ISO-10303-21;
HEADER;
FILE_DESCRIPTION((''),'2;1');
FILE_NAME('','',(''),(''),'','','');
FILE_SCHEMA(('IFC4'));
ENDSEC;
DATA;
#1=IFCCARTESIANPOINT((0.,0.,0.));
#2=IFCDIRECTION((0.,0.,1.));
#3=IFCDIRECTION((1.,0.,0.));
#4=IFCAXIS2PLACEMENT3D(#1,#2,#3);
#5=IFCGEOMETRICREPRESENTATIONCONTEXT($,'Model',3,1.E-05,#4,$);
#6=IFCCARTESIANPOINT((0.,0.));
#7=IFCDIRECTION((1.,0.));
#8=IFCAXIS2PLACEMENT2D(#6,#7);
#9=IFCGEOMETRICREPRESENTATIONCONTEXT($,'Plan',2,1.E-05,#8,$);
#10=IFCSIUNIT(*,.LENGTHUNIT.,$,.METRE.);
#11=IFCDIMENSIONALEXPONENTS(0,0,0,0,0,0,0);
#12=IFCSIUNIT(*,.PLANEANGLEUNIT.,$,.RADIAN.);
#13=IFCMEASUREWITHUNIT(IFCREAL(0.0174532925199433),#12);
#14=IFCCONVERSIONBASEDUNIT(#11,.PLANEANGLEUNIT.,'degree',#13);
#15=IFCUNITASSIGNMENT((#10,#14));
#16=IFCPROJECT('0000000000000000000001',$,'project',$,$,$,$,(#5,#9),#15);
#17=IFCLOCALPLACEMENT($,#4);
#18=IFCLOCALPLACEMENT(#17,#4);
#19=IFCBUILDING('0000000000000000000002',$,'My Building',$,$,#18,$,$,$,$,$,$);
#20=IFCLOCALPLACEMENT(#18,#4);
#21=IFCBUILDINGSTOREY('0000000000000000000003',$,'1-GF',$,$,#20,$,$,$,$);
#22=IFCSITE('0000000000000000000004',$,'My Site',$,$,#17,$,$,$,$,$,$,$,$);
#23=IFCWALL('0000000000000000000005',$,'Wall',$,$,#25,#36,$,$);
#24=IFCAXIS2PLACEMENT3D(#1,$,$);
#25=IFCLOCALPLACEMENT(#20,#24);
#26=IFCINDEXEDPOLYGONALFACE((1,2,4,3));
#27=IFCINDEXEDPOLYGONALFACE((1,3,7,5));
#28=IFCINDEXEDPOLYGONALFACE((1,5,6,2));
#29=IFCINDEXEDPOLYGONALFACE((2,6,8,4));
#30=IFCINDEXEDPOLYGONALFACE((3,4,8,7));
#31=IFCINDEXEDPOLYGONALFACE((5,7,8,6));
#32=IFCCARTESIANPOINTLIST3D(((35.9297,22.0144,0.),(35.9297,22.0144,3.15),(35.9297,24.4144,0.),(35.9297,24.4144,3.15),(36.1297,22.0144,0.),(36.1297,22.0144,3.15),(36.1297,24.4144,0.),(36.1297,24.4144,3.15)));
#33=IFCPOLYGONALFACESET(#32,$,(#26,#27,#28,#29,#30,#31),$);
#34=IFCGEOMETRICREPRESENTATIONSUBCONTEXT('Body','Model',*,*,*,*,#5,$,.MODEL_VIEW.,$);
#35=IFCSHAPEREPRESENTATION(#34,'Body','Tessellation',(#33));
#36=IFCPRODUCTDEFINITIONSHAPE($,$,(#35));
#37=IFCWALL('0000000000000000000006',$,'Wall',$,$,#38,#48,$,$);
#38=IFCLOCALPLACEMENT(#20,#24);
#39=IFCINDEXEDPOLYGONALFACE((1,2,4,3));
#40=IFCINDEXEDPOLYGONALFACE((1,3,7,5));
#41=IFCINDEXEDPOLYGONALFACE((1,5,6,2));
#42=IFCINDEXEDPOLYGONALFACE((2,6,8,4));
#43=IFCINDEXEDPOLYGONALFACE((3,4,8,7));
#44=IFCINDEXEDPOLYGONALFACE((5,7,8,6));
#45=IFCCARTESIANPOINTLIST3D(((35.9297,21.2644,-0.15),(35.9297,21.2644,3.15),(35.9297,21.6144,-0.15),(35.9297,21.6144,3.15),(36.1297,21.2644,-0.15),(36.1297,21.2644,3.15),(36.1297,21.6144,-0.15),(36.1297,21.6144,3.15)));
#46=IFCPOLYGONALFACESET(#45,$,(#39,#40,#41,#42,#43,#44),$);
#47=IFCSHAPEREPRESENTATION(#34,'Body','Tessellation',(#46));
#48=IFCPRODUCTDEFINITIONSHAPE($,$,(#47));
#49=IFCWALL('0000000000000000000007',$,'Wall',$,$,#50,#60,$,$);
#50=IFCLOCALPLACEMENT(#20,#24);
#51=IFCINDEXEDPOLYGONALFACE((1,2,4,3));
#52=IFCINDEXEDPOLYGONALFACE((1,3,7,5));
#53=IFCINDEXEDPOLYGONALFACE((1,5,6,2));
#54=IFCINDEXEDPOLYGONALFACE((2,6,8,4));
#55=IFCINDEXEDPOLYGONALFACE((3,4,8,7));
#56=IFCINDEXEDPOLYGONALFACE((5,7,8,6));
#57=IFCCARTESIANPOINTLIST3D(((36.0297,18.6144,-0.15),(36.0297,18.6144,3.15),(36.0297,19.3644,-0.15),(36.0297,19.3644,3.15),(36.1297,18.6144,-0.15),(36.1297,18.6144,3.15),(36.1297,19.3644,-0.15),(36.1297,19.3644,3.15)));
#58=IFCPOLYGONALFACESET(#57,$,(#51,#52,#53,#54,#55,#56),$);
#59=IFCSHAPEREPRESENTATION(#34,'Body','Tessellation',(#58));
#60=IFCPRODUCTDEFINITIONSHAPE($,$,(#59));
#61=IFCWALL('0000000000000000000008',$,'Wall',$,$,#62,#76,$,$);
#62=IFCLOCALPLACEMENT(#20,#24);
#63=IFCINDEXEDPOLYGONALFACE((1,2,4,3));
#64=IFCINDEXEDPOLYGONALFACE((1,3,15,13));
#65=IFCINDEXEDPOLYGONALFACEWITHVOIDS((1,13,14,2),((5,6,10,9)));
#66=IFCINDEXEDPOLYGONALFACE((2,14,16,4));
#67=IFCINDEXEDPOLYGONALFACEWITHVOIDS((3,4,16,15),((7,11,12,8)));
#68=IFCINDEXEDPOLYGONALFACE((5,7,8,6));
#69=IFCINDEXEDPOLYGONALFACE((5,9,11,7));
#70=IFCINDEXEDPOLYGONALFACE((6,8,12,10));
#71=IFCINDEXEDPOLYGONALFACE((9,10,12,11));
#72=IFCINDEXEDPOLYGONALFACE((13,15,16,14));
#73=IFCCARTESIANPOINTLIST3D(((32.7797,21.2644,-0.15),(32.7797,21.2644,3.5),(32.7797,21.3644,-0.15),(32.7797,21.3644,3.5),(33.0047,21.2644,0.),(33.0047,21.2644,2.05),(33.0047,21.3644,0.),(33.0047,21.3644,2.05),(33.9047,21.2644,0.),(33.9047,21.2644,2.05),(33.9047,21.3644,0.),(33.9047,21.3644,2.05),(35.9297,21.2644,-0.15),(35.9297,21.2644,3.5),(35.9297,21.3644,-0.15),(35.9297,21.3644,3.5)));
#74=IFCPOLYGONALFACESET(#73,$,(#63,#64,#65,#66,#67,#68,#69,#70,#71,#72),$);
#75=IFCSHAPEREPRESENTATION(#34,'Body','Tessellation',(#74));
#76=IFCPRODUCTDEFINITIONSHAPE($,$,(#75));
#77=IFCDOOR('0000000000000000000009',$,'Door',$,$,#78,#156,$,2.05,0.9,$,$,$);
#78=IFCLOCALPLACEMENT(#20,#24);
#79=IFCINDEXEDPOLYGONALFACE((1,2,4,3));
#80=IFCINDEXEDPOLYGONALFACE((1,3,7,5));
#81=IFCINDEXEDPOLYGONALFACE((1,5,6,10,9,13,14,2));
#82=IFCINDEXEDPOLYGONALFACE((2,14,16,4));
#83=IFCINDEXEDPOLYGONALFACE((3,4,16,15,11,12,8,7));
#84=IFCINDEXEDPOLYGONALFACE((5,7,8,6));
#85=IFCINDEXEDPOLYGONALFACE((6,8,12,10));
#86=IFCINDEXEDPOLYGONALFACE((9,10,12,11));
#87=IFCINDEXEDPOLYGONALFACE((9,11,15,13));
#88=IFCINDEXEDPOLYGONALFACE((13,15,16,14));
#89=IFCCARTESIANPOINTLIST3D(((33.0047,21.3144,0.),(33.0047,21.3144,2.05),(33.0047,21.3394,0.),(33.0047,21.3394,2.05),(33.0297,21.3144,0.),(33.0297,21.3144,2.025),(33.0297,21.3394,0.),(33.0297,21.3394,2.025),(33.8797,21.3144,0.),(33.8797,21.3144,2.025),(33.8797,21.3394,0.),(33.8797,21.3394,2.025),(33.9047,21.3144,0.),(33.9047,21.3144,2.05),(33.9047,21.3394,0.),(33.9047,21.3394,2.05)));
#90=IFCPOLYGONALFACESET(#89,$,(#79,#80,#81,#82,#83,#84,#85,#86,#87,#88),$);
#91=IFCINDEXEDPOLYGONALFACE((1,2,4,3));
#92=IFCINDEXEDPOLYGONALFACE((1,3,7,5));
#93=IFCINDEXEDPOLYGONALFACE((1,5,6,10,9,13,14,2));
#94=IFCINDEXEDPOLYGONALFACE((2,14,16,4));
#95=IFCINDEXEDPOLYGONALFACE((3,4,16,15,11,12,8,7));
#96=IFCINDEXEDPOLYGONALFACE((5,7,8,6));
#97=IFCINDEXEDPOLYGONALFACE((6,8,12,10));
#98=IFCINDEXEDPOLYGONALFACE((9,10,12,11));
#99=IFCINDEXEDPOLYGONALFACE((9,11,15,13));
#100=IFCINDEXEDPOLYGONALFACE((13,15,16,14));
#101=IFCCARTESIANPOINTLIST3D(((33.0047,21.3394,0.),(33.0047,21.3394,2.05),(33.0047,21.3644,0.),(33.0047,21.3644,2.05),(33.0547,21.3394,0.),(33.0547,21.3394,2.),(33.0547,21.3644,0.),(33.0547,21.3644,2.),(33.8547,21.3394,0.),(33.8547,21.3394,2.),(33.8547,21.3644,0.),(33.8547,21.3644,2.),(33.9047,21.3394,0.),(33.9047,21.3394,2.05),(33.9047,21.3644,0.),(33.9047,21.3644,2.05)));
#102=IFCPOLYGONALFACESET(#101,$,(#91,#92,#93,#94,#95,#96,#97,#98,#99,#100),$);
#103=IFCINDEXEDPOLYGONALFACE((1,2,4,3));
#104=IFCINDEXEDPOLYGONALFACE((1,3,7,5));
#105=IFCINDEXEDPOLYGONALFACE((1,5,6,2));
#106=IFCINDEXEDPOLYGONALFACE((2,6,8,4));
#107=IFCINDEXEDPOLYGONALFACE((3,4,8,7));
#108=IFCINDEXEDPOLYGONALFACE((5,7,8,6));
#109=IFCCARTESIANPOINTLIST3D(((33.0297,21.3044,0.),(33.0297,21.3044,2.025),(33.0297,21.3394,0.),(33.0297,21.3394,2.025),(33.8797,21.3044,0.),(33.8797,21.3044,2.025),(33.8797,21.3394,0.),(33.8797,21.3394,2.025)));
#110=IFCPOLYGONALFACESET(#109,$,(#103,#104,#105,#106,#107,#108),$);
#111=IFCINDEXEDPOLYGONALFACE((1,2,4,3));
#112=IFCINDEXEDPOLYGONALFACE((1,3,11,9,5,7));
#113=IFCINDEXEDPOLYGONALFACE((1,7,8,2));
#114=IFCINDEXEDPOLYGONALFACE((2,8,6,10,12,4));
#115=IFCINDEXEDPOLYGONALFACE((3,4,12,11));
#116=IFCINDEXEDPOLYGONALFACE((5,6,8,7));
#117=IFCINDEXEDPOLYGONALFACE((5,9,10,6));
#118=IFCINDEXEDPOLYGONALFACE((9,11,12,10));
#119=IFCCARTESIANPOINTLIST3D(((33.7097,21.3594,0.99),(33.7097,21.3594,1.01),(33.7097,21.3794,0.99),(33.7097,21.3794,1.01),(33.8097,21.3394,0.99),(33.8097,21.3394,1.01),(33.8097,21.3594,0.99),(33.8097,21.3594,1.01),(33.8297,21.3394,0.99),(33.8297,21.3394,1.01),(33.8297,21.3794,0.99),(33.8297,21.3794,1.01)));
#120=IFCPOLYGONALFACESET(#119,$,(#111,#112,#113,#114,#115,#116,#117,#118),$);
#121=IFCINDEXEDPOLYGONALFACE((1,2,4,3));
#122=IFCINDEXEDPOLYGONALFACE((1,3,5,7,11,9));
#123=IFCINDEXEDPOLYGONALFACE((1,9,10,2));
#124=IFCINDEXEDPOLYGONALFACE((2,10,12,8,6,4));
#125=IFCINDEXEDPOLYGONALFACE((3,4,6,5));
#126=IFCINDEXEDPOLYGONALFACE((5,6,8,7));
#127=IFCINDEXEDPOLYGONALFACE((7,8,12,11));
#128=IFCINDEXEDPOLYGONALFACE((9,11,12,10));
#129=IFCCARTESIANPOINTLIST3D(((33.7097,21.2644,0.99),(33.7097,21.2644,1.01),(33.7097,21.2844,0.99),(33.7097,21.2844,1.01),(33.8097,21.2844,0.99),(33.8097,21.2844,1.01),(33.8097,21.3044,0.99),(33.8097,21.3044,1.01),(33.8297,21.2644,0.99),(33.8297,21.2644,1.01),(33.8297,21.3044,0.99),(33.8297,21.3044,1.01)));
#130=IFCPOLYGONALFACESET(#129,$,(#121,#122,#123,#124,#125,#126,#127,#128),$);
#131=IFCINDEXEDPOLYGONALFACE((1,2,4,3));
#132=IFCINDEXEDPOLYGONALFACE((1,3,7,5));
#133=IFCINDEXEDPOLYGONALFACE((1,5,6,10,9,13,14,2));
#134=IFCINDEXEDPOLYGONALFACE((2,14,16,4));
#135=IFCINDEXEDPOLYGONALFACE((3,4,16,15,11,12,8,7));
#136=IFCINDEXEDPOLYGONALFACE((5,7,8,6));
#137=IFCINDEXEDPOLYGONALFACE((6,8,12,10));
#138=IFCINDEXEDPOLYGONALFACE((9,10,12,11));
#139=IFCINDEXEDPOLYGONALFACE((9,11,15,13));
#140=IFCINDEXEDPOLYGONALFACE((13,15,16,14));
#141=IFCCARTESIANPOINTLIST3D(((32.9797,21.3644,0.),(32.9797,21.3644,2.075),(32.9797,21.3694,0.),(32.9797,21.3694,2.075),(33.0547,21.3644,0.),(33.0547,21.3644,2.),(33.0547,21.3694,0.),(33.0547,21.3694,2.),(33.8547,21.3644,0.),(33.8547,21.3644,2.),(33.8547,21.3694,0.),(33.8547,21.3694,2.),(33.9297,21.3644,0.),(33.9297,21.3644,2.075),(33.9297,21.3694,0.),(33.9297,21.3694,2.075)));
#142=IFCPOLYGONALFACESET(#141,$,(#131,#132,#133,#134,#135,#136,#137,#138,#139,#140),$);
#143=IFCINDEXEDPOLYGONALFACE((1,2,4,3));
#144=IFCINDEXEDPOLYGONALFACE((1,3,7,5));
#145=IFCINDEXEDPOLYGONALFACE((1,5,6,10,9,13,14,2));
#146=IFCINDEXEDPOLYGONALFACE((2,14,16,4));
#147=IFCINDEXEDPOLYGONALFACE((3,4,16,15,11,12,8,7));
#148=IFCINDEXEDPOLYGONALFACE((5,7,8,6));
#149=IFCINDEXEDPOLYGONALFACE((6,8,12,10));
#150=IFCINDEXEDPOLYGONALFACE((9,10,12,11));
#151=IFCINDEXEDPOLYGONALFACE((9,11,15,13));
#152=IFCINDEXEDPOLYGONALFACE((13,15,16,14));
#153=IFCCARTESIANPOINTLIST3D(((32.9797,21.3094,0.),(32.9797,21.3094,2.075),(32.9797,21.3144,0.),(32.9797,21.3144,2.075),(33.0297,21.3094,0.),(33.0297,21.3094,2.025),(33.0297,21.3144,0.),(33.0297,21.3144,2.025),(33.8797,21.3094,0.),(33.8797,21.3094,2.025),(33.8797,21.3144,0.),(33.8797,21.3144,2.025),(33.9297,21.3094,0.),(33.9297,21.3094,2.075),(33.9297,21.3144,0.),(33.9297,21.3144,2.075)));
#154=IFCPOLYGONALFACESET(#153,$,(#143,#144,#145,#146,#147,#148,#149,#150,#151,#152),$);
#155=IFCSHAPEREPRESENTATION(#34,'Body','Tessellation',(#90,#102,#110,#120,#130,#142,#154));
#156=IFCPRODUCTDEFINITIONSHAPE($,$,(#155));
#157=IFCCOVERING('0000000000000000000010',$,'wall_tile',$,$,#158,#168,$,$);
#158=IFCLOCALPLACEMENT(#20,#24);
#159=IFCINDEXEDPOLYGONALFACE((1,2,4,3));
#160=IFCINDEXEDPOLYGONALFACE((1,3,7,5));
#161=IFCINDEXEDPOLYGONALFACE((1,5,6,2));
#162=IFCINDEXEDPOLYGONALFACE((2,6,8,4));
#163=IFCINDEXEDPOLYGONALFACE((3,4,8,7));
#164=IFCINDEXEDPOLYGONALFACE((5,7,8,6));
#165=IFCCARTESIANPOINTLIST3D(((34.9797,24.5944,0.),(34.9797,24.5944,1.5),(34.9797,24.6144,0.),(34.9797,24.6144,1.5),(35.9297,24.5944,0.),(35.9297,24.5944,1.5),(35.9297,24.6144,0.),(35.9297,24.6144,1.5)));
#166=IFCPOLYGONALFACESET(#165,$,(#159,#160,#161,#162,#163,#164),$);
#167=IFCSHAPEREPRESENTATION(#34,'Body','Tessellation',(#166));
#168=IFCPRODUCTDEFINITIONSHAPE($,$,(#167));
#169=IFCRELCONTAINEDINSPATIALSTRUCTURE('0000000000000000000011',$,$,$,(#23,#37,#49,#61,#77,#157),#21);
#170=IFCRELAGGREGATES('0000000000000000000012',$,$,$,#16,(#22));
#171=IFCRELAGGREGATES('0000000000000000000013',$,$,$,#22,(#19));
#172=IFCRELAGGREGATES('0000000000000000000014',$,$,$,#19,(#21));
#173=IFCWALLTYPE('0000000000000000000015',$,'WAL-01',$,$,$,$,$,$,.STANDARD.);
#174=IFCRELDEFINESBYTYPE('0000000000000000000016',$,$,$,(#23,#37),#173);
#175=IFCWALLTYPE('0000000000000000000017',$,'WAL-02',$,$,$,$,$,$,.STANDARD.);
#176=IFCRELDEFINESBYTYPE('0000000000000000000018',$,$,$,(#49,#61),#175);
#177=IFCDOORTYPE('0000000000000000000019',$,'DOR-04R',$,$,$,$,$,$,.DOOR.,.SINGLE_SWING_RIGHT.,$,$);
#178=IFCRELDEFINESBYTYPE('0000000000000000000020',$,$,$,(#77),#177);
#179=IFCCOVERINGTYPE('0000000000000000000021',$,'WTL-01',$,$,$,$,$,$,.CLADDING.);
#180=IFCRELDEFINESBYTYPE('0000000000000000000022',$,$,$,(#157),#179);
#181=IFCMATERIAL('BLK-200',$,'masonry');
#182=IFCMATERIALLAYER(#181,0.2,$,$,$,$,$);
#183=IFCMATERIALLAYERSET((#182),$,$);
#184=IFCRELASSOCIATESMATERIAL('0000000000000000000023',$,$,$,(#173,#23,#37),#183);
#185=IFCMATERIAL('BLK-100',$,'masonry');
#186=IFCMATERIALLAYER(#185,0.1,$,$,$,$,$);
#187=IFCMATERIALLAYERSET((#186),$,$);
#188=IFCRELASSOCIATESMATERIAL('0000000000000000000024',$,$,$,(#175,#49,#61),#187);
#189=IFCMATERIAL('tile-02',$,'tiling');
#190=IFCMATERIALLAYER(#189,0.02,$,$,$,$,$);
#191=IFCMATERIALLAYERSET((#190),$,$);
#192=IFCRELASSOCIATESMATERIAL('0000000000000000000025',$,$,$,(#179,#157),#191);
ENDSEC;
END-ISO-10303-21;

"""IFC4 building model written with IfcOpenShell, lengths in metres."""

from ifc_helpers import new_model, entity, si_unit, converted_unit, frame, origin_with_axes, origin_2d_with_axis, place, context, subcontext, project, spatial, line, indexed_curve, outline, extrude, shape, source, transform, mapped, material, layer, layer_set, layer_usage, type_object, type_shapes, element, fill, save


model = new_model("IFC4")

# Units and contexts
model_context = context("Model", 3, precision=1e-05, world=origin_with_axes())
plan_context = context("Plan", 2, precision=1e-05, world=origin_2d_with_axis())
body_context_1 = subcontext(model_context, "Body", "Model", "MODEL_VIEW")
body_context_2 = subcontext(plan_context, "Body", "Plan", "PLAN_VIEW")
ifc_project = project(units=[si_unit("LENGTHUNIT", "METRE"), converted_unit("PLANEANGLEUNIT", "degree", entity("IfcReal", 0.0174532925199433), si_unit("PLANEANGLEUNIT", "RADIAN"), dimensions=[0, 0, 0, 0, 0, 0, 0])], contexts=[model_context, plan_context])

# Site, building, storey
site_placement = place(None, origin_with_axes())
site = spatial("IfcSite", under=ifc_project, at=site_placement, Name="My Site")
building_placement = place(site_placement, origin_with_axes())
building = spatial("IfcBuilding", under=site, at=building_placement, Name="My Building")
storey_placement = place(building_placement, origin_with_axes())
storey = spatial("IfcBuildingStorey", under=building, at=storey_placement, Name="1-GF")

# Wall
ifc_material_1 = material(Name="BLK-200", Category="masonry")
ifc_layer_1 = layer(ifc_material_1, 0.2)
ifc_layer_set_1 = layer_set([ifc_layer_1])
ifc_layer_usage_1 = layer_usage(ifc_layer_set_1, "AXIS2", "POSITIVE", 0.0)
wall_type_1 = type_object("IfcWallType", Name="WAL-01", PredefinedType="STANDARD", material=ifc_layer_set_1)
wall_1_placement = place(storey_placement, frame((36.1297, 22.0144, 0.0), z_axis=(0.0, 0.0, 1.0), x_axis=(0.000001, 1.0, 0.0)))
element("IfcWall", 1, at=wall_1_placement, inside=storey, type_object=wall_type_1, material=ifc_layer_usage_1, Name="Wall", context=body_context_1, shape_type="SweptSolid", body=[
    extrude(outline(indexed_curve([(0.0, 0.0), (0.0, 0.2), (2.4, 0.2), (2.4, 0.0), (0.0, 0.0)], self_intersect=False)), origin_with_axes(), (0.0, 0.0, 1.0), 3.15),
])

# Walls
ifc_layer_usage_2 = layer_usage(ifc_layer_set_1, "AXIS2", "POSITIVE", 0.0)
wall_2_placement = place(storey_placement, frame((36.1297, 21.2644, -0.15), z_axis=(0.0, 0.0, 1.0), x_axis=(0.000001, 1.0, 0.0)))
element("IfcWall", 2, at=wall_2_placement, inside=storey, type_object=wall_type_1, material=ifc_layer_usage_2, Name="Wall", context=body_context_1, shape_type="SweptSolid", body=[
    extrude(outline(indexed_curve([(0.0, 0.0), (0.0, 0.2), (0.35, 0.2), (0.35, 0.0), (0.0, 0.0)], self_intersect=False)), origin_with_axes(), (0.0, 0.0, 1.0), 3.3),
])
ifc_material_2 = material(Name="BLK-100", Category="masonry")
ifc_layer_2 = layer(ifc_material_2, 0.1)
ifc_layer_set_2 = layer_set([ifc_layer_2])
ifc_layer_usage_3 = layer_usage(ifc_layer_set_2, "AXIS2", "POSITIVE", 0.0)
wall_type_2 = type_object("IfcWallType", Name="WAL-02", PredefinedType="STANDARD", material=ifc_layer_set_2)
wall_3_placement = place(storey_placement, frame((36.1297, 18.6144, -0.15), z_axis=(0.0, 0.0, 1.0), x_axis=(0.0, 1.0, 0.0)))
element("IfcWall", 3, at=wall_3_placement, inside=storey, type_object=wall_type_2, material=ifc_layer_usage_3, Name="Wall", context=body_context_1, shape_type="SweptSolid", body=[
    extrude(outline(indexed_curve([(0.0, 0.0), (0.0, 0.1), (0.75, 0.1), (0.75, 0.0), (0.0, 0.0)], self_intersect=False)), origin_with_axes(), (0.0, 0.0, 1.0), 3.3),
])

# Wall, opening, door
ifc_layer_usage_4 = layer_usage(ifc_layer_set_2, "AXIS2", "POSITIVE", 0.0)
wall_4_placement = place(storey_placement, frame((35.9297, 21.3644, -0.15), z_axis=(0.0, 0.0, 1.0), x_axis=(-1.0, 0.000001, 0.0)))
wall_4 = element("IfcWall", 4, at=wall_4_placement, inside=storey, type_object=wall_type_2, material=ifc_layer_usage_4, Name="Wall", context=body_context_1, shape_type="SweptSolid", body=[
    extrude(outline(indexed_curve([(0.0, 0.0), (0.0, 0.1), (3.15, 0.1), (3.15, 0.0), (0.0, 0.0)], self_intersect=False)), origin_with_axes(), (0.0, 0.0, 1.0), 3.65),
])
shared_shape_1 = source(origin_with_axes(), body_context_1, "Body", "SweptSolid", [
    extrude(outline(indexed_curve([(0.0, 0.0), (0.9, 0.0), (0.9, 2.05), (0.0, 2.05)], segments=[line(1, 2, 3, 4, 1)])), frame((0.0, -0.6, 0.0), z_axis=(0.0, -1.0, 0.0), x_axis=(1.0, 0.0, 0.0)), (0.0, 0.0, -1.0), 1.2),
])
opening_1_placement = place(wall_4_placement, frame((2.025, 0.0, 0.15), z_axis=(0.0, 0.0, 1.0), x_axis=(1.0, 0.0, 0.0)))
opening_1 = element("IfcOpeningElement", 5, at=opening_1_placement, cuts=wall_4, PredefinedType="OPENING", context=body_context_1, shape_type="MappedRepresentation", body=[
    mapped(shared_shape_1, transform((0.0, 0.0, 0.0), x_axis=(1.0, 0.0, 0.0), y_axis=(0.0, 1.0, 0.0), z_axis=(0.0, 0.0, 1.0), scale=1.0)),
])
door_type_1 = type_object("IfcDoorType", Name="DOR-04R", OperationType="SINGLE_SWING_RIGHT", PredefinedType="DOOR")
shared_shape_2 = source(origin_with_axes(), body_context_1, "Body", "SweptSolid", [
    extrude(outline(indexed_curve([(0.0, 0.0), (0.0, 2.05), (0.9, 2.05), (0.9, 0.0), (0.875, 0.0), (0.875, 2.025), (0.025, 2.025), (0.025, 0.0)], segments=[line(1, 2, 3, 4, 5, 6, 7, 8, 1)])), frame((0.0, 0.025, 0.0), z_axis=(0.0, -1.0, 0.0), x_axis=(1.0, 0.0, 0.0)), (0.0, 0.0, -1.0), 0.025),
    extrude(outline(indexed_curve([(0.0, 0.0), (0.0, 2.05), (0.9, 2.05), (0.9, 0.0), (0.85, 0.0), (0.85, 2.0), (0.05, 2.0), (0.05, 0.0)], segments=[line(1, 2, 3, 4, 5, 6, 7, 8, 1)])), frame((0.0, 0.0, 0.0), z_axis=(0.0, -1.0, 0.0), x_axis=(1.0, 0.0, 0.0)), (0.0, 0.0, -1.0), 0.025),
    extrude(outline(indexed_curve([(0.0, 0.0), (0.85, 0.0), (0.85, 0.035), (0.0, 0.035)], segments=[line(1, 2, 3, 4, 1)])), frame((0.025, 0.025, 0.0), z_axis=(0.0, 0.0, 1.0), x_axis=(1.0, 0.0, 0.0)), (0.0, 0.0, 1.0), 2.025),
    extrude(outline(indexed_curve([(0.0, 0.0), (0.0, -0.04), (0.12, -0.04), (0.12, -0.02), (0.02, -0.02), (0.02, 0.0)], segments=[line(1, 2, 3, 4, 5, 6, 1)])), frame((0.075, 0.025, 0.99), z_axis=(0.0, 0.0, 1.0), x_axis=(1.0, 0.0, 0.0)), (0.0, 0.0, 1.0), 0.02),
    extrude(outline(indexed_curve([(0.0, 0.0), (0.0, 0.04), (0.12, 0.04), (0.12, 0.02), (0.02, 0.02), (0.02, 0.0)], segments=[line(1, 2, 3, 4, 5, 6, 1)])), frame((0.075, 0.06, 0.99), z_axis=(0.0, 0.0, 1.0), x_axis=(1.0, 0.0, 0.0)), (0.0, 0.0, 1.0), 0.02),
    extrude(outline(indexed_curve([(0.0, 0.0), (0.0, 2.075), (0.95, 2.075), (0.95, 0.0), (0.875, 0.0), (0.875, 2.0), (0.075, 2.0), (0.075, 0.0)], segments=[line(1, 2, 3, 4, 5, 6, 7, 8, 1)])), frame((-0.025, -0.005, 0.0), z_axis=(0.0, -1.0, 0.0), x_axis=(1.0, 0.0, 0.0)), (0.0, 0.0, -1.0), 0.005),
    extrude(outline(indexed_curve([(0.0, 0.0), (0.0, 2.075), (0.95, 2.075), (0.95, 0.0), (0.9, 0.0), (0.9, 2.025), (0.05, 2.025), (0.05, 0.0)], segments=[line(1, 2, 3, 4, 5, 6, 7, 8, 1)])), frame((-0.025, 0.05, 0.0), z_axis=(0.0, -1.0, 0.0), x_axis=(1.0, 0.0, 0.0)), (0.0, 0.0, -1.0), 0.005),
])
shared_shape_3 = source(origin_with_axes(), body_context_2, "Body", "Curve2D", [
    entity("IfcIndexedPolyCurve", entity("IfcCartesianPointList2D", [[0.0, 0.0], [0.0, 0.05], [0.025, 0.05], [0.025, 0.025], [0.05, 0.025], [0.05, 0.0]]), [entity("IfcLineIndex", [1, 2, 3, 4, 5, 6, 1])]),
    entity("IfcIndexedPolyCurve", entity("IfcCartesianPointList2D", [[0.9, 0.0], [0.9, 0.05], [0.875, 0.05], [0.875, 0.025], [0.85, 0.025], [0.85, 0.0]]), [entity("IfcLineIndex", [1, 2, 3, 4, 5, 6, 1])]),
    entity("IfcTrimmedCurve", entity("IfcEllipse", entity("IfcAxis2Placement2D", entity("IfcCartesianPoint", [0.84, 0.05]), entity("IfcDirection", [1.0, 0.0])), 0.815, 0.85), [entity("IfcCartesianPoint", [0.84, 0.9])], [entity("IfcCartesianPoint", [0.025, 0.05])], True, "CARTESIAN"),
    entity("IfcIndexedPolyCurve", entity("IfcCartesianPointList2D", [[0.875, 0.05], [0.84, 0.05], [0.84, 0.9], [0.875, 0.9]]), [entity("IfcLineIndex", [1, 2, 3, 4, 1])]),
])
type_shapes(door_type_1, [shared_shape_2, shared_shape_3])
door_1_placement = place(opening_1_placement, frame((0.0, 0.0, 0.0), z_axis=(0.0, 0.0, 1.0), x_axis=(1.0, 0.0, 0.0)))
door_1 = element("IfcDoor", 6, at=door_1_placement, inside=storey, type_object=door_type_1, Name="Door", OverallHeight=2.05, OverallWidth=0.9, shapes=[
    shape(body_context_1, "Body", "MappedRepresentation", [mapped(shared_shape_2, transform((0.0, 0.0, 0.0), x_axis=(1.0, 0.0, 0.0), y_axis=(0.0, 1.0, 0.0), z_axis=(0.0, 0.0, 1.0), scale=1.0))]),
    shape(body_context_2, "Body", "MappedRepresentation", [mapped(shared_shape_3, transform((0.0, 0.0, 0.0), x_axis=(1.0, 0.0, 0.0), y_axis=(0.0, 1.0, 0.0), z_axis=(0.0, 0.0, 1.0), scale=1.0))]),
])
fill(opening_1, door_1)

# Covering
ifc_material_3 = material(Name="tile-02", Category="tiling")
ifc_layer_3 = layer(ifc_material_3, 0.02)
ifc_layer_set_3 = layer_set([ifc_layer_3])
ifc_layer_usage_5 = layer_usage(ifc_layer_set_3, "AXIS2", "POSITIVE", 0.0)
covering_type = type_object("IfcCoveringType", Name="WTL-01", PredefinedType="CLADDING", material=ifc_layer_set_3)
covering_1_placement = place(storey_placement, frame((35.9297, 24.6144, 0.0), z_axis=(0.0, 0.0, 1.0), x_axis=(-1.0, 0.000001, 0.0)))
element("IfcCovering", 7, at=covering_1_placement, inside=storey, type_object=covering_type, material=ifc_layer_usage_5, Name="wall_tile", context=body_context_1, shape_type="SweptSolid", body=[
    extrude(outline(indexed_curve([(0.0, 0.0), (0.0, 0.02), (0.95, 0.02), (0.95, 0.0), (0.0, 0.0)], self_intersect=False)), origin_with_axes(), (0.0, 0.0, 1.0), 1.5),
])

save(model, "model.ifc")
